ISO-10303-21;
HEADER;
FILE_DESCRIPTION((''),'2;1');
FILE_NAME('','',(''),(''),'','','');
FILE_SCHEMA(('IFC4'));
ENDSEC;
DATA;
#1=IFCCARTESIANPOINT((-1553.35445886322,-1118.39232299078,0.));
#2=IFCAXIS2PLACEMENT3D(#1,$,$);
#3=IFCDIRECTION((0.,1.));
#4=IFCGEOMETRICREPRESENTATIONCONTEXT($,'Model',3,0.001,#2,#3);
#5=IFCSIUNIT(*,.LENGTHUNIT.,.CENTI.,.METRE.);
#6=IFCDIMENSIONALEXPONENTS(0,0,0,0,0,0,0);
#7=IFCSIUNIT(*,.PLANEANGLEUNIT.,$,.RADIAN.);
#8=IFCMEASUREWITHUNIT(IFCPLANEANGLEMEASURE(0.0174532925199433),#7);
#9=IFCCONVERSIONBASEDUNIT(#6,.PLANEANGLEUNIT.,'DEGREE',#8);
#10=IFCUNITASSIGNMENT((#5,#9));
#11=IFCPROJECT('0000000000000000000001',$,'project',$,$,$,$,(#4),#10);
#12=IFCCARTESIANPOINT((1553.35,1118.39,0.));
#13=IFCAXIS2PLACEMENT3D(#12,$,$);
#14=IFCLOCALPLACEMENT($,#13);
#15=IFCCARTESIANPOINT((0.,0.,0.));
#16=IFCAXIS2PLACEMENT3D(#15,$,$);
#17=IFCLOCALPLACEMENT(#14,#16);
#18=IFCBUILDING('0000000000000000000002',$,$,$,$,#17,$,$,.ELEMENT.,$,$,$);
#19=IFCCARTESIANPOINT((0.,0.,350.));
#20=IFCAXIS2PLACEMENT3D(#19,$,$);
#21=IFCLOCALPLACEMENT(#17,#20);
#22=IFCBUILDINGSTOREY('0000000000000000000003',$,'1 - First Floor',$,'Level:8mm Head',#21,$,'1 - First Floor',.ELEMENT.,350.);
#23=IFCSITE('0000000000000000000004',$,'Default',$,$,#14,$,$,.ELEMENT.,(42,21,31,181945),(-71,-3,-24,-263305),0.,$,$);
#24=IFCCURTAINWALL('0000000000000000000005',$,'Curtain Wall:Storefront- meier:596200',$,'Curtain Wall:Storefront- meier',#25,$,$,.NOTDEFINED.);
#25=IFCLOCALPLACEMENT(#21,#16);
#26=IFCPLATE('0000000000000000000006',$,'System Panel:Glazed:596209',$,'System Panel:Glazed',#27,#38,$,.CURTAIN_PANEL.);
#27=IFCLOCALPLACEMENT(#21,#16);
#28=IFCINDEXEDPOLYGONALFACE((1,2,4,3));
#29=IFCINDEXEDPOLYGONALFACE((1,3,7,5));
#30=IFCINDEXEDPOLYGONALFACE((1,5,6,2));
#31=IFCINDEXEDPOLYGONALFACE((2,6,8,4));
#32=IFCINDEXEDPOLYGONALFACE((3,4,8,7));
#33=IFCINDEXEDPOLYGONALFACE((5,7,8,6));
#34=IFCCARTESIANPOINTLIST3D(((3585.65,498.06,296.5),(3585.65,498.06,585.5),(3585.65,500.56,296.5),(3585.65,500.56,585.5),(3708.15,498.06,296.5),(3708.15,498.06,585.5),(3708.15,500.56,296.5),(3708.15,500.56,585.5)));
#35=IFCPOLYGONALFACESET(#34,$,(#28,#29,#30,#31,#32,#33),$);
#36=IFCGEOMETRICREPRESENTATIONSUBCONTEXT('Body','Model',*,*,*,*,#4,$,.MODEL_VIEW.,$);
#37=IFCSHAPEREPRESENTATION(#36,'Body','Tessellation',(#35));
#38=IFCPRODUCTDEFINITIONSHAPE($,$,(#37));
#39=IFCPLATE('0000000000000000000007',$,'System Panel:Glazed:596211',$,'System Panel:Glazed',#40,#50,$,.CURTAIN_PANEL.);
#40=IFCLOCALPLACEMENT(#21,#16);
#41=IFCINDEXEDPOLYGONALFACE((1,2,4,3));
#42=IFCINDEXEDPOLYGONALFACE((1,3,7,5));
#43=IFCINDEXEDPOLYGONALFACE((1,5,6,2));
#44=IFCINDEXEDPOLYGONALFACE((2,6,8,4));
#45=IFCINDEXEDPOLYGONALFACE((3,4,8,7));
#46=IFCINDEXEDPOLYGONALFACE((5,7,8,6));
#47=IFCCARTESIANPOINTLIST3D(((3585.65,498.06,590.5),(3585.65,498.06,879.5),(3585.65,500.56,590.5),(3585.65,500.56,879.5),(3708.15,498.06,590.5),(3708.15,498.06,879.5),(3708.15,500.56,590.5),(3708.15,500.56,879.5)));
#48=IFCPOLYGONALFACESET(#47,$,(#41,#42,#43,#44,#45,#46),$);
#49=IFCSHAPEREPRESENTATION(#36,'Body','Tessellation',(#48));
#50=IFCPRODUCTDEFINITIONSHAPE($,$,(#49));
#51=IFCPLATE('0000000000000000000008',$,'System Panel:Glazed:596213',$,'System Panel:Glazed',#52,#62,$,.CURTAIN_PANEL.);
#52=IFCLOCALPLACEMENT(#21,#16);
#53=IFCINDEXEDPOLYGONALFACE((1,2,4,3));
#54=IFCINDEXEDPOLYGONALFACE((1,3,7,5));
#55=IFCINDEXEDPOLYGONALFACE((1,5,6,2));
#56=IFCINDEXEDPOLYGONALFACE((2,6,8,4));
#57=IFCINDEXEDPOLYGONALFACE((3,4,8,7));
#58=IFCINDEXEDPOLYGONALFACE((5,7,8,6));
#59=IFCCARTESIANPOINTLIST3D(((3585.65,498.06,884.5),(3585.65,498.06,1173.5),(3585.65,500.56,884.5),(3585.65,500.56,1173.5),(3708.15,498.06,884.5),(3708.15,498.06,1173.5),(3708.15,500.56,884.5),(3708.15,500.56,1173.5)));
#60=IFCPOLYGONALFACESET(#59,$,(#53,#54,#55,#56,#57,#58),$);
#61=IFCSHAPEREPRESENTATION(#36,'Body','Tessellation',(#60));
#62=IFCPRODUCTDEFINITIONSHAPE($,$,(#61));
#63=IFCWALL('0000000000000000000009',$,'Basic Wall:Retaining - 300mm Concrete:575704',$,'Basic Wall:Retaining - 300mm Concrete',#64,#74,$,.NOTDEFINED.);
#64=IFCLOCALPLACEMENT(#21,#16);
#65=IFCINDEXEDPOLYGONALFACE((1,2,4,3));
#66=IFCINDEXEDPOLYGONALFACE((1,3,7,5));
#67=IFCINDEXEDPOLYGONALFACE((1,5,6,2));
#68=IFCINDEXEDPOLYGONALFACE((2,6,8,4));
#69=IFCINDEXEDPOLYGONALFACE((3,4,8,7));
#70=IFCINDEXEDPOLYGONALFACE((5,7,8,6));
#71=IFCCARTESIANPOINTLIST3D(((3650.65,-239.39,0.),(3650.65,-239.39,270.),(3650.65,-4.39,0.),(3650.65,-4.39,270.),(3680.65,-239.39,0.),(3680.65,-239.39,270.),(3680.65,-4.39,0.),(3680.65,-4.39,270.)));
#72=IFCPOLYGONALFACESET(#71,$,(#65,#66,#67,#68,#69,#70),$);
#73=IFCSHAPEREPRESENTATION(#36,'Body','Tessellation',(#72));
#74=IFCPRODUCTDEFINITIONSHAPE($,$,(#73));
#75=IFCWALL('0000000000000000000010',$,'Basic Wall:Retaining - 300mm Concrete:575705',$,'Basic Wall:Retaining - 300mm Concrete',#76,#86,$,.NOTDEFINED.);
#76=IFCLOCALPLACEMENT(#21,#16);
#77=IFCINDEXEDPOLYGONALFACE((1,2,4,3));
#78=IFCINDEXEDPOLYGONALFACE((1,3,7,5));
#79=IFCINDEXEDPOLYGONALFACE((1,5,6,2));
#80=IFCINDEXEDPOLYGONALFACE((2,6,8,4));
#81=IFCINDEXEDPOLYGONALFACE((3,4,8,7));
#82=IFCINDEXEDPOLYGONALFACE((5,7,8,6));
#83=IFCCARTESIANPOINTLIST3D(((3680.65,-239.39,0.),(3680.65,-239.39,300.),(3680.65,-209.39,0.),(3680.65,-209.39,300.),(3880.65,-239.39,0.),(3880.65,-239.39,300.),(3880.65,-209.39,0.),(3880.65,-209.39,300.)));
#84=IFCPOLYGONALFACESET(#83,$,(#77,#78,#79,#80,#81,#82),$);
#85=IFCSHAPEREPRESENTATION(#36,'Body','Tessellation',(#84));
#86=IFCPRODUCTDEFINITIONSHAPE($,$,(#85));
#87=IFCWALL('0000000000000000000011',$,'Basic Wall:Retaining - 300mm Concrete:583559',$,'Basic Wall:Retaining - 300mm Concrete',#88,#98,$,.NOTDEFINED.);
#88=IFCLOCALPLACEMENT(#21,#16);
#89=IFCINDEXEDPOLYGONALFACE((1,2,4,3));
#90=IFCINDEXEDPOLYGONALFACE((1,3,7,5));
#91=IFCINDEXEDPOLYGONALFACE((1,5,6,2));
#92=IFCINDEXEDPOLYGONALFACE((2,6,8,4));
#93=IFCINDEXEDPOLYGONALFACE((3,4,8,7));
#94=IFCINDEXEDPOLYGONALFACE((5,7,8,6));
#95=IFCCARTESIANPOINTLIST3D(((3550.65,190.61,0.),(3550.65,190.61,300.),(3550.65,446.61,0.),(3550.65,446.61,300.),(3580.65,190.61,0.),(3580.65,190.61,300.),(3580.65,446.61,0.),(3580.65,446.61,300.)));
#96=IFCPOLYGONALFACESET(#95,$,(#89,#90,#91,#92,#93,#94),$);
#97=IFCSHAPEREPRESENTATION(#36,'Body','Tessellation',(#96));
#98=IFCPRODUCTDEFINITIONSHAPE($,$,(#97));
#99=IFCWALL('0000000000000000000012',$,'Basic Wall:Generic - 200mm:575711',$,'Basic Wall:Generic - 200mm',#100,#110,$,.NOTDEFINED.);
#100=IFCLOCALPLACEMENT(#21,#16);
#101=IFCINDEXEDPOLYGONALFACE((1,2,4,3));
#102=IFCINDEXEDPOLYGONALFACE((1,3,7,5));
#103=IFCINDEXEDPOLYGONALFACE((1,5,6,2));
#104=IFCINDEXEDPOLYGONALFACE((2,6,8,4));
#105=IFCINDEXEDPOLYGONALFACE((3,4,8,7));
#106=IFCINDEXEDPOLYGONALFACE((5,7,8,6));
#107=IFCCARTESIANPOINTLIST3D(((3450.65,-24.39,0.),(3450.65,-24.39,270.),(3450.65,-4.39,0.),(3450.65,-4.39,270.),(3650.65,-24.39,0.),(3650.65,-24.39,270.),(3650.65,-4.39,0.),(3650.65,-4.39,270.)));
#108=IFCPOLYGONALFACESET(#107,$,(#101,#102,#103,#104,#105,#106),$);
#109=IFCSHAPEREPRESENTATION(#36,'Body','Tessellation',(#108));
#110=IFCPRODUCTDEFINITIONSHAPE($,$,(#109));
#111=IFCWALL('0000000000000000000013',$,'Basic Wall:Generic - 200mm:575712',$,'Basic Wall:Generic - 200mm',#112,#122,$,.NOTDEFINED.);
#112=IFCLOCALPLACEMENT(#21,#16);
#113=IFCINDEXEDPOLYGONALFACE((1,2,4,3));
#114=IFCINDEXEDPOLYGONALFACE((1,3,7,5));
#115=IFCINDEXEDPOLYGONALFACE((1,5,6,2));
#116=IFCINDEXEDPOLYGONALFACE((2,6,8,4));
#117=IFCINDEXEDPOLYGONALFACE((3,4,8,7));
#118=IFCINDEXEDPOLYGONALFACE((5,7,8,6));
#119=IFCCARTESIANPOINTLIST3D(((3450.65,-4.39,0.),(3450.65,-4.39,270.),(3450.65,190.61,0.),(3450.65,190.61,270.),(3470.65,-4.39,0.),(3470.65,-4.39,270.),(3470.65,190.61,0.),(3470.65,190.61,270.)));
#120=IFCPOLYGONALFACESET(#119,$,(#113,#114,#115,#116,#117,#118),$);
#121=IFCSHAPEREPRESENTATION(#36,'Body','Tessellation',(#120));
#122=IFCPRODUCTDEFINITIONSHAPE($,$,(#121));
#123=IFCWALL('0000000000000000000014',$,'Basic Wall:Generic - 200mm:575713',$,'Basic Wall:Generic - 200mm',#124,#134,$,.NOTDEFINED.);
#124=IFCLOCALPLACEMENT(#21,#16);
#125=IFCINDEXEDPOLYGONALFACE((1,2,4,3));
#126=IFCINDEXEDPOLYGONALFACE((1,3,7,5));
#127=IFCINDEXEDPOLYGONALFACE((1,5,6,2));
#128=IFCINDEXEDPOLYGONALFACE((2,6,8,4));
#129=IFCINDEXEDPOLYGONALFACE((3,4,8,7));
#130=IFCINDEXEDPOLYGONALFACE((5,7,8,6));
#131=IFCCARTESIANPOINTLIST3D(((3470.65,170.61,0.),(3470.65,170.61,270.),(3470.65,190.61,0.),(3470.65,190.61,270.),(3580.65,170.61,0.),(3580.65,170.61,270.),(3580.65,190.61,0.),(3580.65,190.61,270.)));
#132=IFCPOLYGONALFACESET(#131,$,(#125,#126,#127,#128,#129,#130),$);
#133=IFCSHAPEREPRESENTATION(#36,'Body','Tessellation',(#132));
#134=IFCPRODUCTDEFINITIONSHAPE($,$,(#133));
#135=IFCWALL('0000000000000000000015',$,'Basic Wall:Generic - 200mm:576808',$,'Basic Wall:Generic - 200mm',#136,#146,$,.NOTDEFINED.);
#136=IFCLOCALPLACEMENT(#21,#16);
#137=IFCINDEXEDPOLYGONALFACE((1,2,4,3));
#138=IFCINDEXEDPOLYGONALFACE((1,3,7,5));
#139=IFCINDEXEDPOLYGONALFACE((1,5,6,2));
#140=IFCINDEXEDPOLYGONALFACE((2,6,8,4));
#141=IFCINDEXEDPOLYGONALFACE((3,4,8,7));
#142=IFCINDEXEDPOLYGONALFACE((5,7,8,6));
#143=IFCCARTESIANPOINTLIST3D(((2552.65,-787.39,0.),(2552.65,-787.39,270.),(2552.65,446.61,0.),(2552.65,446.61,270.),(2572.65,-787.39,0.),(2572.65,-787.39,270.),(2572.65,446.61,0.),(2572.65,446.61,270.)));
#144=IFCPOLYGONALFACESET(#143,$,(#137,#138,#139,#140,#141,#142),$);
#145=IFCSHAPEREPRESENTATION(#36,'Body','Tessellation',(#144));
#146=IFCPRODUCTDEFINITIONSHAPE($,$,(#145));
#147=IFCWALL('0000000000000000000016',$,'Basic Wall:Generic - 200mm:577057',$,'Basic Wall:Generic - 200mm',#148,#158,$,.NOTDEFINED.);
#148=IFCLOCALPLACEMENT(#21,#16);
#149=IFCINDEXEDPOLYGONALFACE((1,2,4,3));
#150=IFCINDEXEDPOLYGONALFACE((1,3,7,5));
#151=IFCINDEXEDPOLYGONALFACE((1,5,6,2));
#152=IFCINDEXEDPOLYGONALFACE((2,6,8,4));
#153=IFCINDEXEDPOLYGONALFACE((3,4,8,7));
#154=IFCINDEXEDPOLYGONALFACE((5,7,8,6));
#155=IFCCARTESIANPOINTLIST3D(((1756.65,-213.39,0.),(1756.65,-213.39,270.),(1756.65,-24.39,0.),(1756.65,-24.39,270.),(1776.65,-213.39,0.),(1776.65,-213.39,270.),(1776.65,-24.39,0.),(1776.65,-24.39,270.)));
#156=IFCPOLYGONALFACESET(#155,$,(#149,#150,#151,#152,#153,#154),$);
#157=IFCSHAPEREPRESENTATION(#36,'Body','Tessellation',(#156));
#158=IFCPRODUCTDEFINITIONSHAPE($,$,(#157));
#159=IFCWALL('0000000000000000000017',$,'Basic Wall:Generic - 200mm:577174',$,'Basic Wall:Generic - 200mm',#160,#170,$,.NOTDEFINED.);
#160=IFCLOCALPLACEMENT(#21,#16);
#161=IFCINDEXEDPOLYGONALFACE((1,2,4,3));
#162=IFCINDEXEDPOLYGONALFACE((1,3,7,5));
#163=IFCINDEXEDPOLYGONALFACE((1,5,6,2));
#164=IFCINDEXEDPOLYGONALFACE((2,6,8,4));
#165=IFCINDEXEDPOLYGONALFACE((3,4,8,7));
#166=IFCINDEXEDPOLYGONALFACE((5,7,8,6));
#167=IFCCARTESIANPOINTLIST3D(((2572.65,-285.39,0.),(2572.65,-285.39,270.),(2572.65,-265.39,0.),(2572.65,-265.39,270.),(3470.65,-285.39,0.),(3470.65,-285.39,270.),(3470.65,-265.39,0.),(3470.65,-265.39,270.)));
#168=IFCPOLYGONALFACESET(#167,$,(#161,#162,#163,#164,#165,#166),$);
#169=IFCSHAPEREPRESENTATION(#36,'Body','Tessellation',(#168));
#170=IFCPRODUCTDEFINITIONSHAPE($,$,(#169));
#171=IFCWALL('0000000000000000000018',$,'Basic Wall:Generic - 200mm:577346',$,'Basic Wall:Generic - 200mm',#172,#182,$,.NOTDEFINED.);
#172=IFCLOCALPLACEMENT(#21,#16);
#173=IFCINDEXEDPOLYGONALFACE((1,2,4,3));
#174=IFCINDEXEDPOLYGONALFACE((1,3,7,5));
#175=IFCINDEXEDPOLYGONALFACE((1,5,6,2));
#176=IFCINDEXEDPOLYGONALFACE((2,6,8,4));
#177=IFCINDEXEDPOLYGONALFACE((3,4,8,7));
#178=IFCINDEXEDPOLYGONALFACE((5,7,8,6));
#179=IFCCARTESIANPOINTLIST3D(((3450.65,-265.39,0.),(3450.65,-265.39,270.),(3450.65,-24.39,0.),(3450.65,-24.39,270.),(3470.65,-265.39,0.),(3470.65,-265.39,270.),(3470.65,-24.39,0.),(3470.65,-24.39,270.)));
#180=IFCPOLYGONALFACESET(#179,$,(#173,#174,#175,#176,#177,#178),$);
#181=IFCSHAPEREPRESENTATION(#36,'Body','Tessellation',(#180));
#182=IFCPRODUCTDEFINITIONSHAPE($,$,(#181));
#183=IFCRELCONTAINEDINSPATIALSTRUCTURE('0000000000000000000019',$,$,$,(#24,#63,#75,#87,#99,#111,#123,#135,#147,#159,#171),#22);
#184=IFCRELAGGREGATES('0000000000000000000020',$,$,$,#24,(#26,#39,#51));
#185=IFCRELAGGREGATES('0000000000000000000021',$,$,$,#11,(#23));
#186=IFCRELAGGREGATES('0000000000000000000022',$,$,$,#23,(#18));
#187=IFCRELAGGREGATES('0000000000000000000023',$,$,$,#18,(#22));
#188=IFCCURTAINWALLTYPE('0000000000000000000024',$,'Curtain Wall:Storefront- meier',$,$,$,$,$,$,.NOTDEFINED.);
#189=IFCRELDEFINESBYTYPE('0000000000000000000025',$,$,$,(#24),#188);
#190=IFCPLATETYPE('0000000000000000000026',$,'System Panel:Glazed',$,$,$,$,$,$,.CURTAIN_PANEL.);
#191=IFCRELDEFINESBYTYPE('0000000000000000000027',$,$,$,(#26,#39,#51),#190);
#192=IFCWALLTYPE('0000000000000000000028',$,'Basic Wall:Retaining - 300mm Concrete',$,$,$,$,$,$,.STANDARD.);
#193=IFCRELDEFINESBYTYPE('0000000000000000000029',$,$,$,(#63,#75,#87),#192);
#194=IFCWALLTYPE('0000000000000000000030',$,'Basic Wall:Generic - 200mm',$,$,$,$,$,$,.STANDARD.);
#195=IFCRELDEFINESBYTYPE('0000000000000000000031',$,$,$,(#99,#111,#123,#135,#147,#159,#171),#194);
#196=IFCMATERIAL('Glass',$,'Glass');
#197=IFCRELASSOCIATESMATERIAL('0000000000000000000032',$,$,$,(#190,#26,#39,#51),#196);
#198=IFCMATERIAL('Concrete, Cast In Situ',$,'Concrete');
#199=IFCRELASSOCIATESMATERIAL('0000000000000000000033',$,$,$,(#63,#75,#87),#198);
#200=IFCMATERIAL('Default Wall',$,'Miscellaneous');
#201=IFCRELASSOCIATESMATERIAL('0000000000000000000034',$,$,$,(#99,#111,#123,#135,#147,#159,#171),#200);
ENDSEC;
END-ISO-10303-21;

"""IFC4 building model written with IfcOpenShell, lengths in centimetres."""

from ifc_helpers import new_model, entity, si_unit, converted_unit, direction, frame, origin, place, context, subcontext, project, spatial, indexed_curve, outline, extrude, source, transform, mapped, material, type_object, type_shapes, element, aggregate, save


model = new_model("IFC4")

# Units and contexts
model_context = context("Model", 3, precision=0.001, world=frame((-1553.35445886322, -1118.39232299078, 0.0)), true_north=direction((0.0, 1.0)))
body_context = subcontext(model_context, "Body", "Model", "MODEL_VIEW")
ifc_project = project(units=[si_unit("LENGTHUNIT", "METRE", prefix="CENTI"), converted_unit("PLANEANGLEUNIT", "DEGREE", entity("IfcPlaneAngleMeasure", 0.0174532925199433), si_unit("PLANEANGLEUNIT", "RADIAN"), dimensions=[0, 0, 0, 0, 0, 0, 0])], contexts=[model_context])

# Site, building, storey
site_placement = place(None, frame((1553.35, 1118.39, 0.0)))
site = spatial("IfcSite", under=ifc_project, at=site_placement, Name="Default", CompositionType="ELEMENT", RefLatitude=(42, 21, 31, 181945), RefLongitude=(-71, -3, -24, -263305), RefElevation=0.0)
building_placement = place(site_placement, origin())
building = spatial("IfcBuilding", under=site, at=building_placement, CompositionType="ELEMENT")
storey_placement = place(building_placement, frame((0.0, 0.0, 350.0)))
storey = spatial("IfcBuildingStorey", under=building, at=storey_placement, Name="1 - First Floor", ObjectType="Level:8mm Head", LongName="1 - First Floor", CompositionType="ELEMENT", Elevation=350.0)

# Curtain wall, plates
curtain_wall_type = type_object("IfcCurtainWallType", Name="Curtain Wall:Storefront- meier", PredefinedType="NOTDEFINED")
curtain_wall_placement = place(storey_placement, frame((0.0, 0.0, -350.0)))
curtain_wall = element("IfcCurtainWall", 1, at=curtain_wall_placement, inside=storey, type_object=curtain_wall_type, Name="Curtain Wall:Storefront- meier:596200", ObjectType="Curtain Wall:Storefront- meier", PredefinedType="NOTDEFINED")
ifc_material_1 = material(Name="Glass", Category="Glass")
plate_type_1 = type_object("IfcPlateType", Name="System Panel:Glazed", PredefinedType="CURTAIN_PANEL", material=ifc_material_1)
shared_shape_1 = source(origin(), body_context, "Body", "SweptSolid", [
    extrude(outline(indexed_curve([(-1.25, -61.25), (1.25, -61.25), (1.25, 61.25), (-1.25, 61.25), (-1.25, -61.25)], self_intersect=False)), frame((0.0, 3.7, 0.0), z_axis=(0.0, 0.0, 1.0), x_axis=(0.0, 1.0, 0.0)), (0.0, 0.0, 1.0), 289.0),
])
type_shapes(plate_type_1, [shared_shape_1])
plate_1_placement = place(curtain_wall_placement, frame((3646.9, 495.61, 646.5)))
plate_1 = element("IfcPlate", 2, at=plate_1_placement, type_object=plate_type_1, material=ifc_material_1, Name="System Panel:Glazed:596209", ObjectType="System Panel:Glazed", PredefinedType="CURTAIN_PANEL", context=body_context, shape_type="MappedRepresentation", body=[
    mapped(shared_shape_1, transform((0.0, 0.0, 0.0), scale=1.0)),
])
plate_2_placement = place(curtain_wall_placement, frame((3646.9, 495.61, 940.5)))
plate_2 = element("IfcPlate", 3, at=plate_2_placement, type_object=plate_type_1, material=ifc_material_1, Name="System Panel:Glazed:596211", ObjectType="System Panel:Glazed", PredefinedType="CURTAIN_PANEL", context=body_context, shape_type="MappedRepresentation", body=[
    mapped(shared_shape_1, transform((0.0, 0.0, 0.0), scale=1.0)),
])
plate_3_placement = place(curtain_wall_placement, frame((3646.9, 495.61, 1234.5)))
plate_3 = element("IfcPlate", 4, at=plate_3_placement, type_object=plate_type_1, material=ifc_material_1, Name="System Panel:Glazed:596213", ObjectType="System Panel:Glazed", PredefinedType="CURTAIN_PANEL", context=body_context, shape_type="MappedRepresentation", body=[
    mapped(shared_shape_1, transform((0.0, 0.0, 0.0), scale=1.0)),
])
aggregate(curtain_wall, [plate_1, plate_2, plate_3])

# Walls
ifc_material_2 = material(Name="Concrete, Cast In Situ", Category="Concrete")
wall_type_1 = type_object("IfcWallType", Name="Basic Wall:Retaining - 300mm Concrete", PredefinedType="STANDARD")
wall_1_placement = place(storey_placement, frame((3665.65, -4.39, 0.0), z_axis=(0.0, 0.0, 1.0), x_axis=(0.0, -1.0, 0.0)))
element("IfcWall", 5, at=wall_1_placement, inside=storey, type_object=wall_type_1, material=ifc_material_2, Name="Basic Wall:Retaining - 300mm Concrete:575704", ObjectType="Basic Wall:Retaining - 300mm Concrete", PredefinedType="NOTDEFINED", context=body_context, shape_type="SweptSolid", body=[
    extrude(outline(indexed_curve([(235.0, 15.0), (0.0, 15.0), (0.0, -15.0), (235.0, -15.0), (235.0, 15.0)], self_intersect=False)), origin(), (0.0, 0.0, 1.0), 270.0),
])
wall_2_placement = place(storey_placement, frame((3680.65, -224.39, 0.0)))
element("IfcWall", 6, at=wall_2_placement, inside=storey, type_object=wall_type_1, material=ifc_material_2, Name="Basic Wall:Retaining - 300mm Concrete:575705", ObjectType="Basic Wall:Retaining - 300mm Concrete", PredefinedType="NOTDEFINED", context=body_context, shape_type="SweptSolid", body=[
    extrude(outline(indexed_curve([(200.0, 15.0), (0.0, 15.0), (0.0, -15.0), (200.0, -15.0), (200.0, 15.0)], self_intersect=False)), origin(), (0.0, 0.0, 1.0), 300.0),
])
wall_3_placement = place(storey_placement, frame((3565.65, 446.61, 0.0), z_axis=(0.0, 0.0, 1.0), x_axis=(0.0, -1.0, 0.0)))
element("IfcWall", 7, at=wall_3_placement, inside=storey, type_object=wall_type_1, material=ifc_material_2, Name="Basic Wall:Retaining - 300mm Concrete:583559", ObjectType="Basic Wall:Retaining - 300mm Concrete", PredefinedType="NOTDEFINED", context=body_context, shape_type="SweptSolid", body=[
    extrude(outline(indexed_curve([(256.0, 15.0), (0.0, 15.0), (0.0, -15.0), (256.0, -15.0), (256.0, 15.0)], self_intersect=False)), origin(), (0.0, 0.0, 1.0), 300.0),
])
ifc_material_3 = material(Name="Default Wall", Category="Miscellaneous")
wall_type_2 = type_object("IfcWallType", Name="Basic Wall:Generic - 200mm", PredefinedType="STANDARD")
wall_4_placement = place(storey_placement, frame((3650.65, -14.39, 0.0), z_axis=(0.0, 0.0, 1.0), x_axis=(-1.0, 0.0, 0.0)))
element("IfcWall", 8, at=wall_4_placement, inside=storey, type_object=wall_type_2, material=ifc_material_3, Name="Basic Wall:Generic - 200mm:575711", ObjectType="Basic Wall:Generic - 200mm", PredefinedType="NOTDEFINED", context=body_context, shape_type="SweptSolid", body=[
    extrude(outline(indexed_curve([(200.0, 10.0), (0.0, 10.0), (0.0, -10.0), (200.0, -10.0), (200.0, 10.0)], self_intersect=False)), origin(), (0.0, 0.0, 1.0), 270.0),
])
wall_5_placement = place(storey_placement, frame((3460.65, -4.39, 0.0), z_axis=(0.0, 0.0, 1.0), x_axis=(0.0, 1.0, 0.0)))
element("IfcWall", 9, at=wall_5_placement, inside=storey, type_object=wall_type_2, material=ifc_material_3, Name="Basic Wall:Generic - 200mm:575712", ObjectType="Basic Wall:Generic - 200mm", PredefinedType="NOTDEFINED", context=body_context, shape_type="SweptSolid", body=[
    extrude(outline(indexed_curve([(195.0, 10.0), (0.0, 10.0), (0.0, -10.0), (195.0, -10.0), (195.0, 10.0)], self_intersect=False)), origin(), (0.0, 0.0, 1.0), 270.0),
])
wall_6_placement = place(storey_placement, frame((3470.65, 180.61, 0.0)))
element("IfcWall", 10, at=wall_6_placement, inside=storey, type_object=wall_type_2, material=ifc_material_3, Name="Basic Wall:Generic - 200mm:575713", ObjectType="Basic Wall:Generic - 200mm", PredefinedType="NOTDEFINED", context=body_context, shape_type="SweptSolid", body=[
    extrude(outline(indexed_curve([(110.0, 10.0), (0.0, 10.0), (0.0, -10.0), (110.0, -10.0), (110.0, 10.0)], self_intersect=False)), origin(), (0.0, 0.0, 1.0), 270.0),
])
wall_7_placement = place(storey_placement, frame((2562.65, 446.61, 0.0), z_axis=(0.0, 0.0, 1.0), x_axis=(0.0, -1.0, 0.0)))
element("IfcWall", 11, at=wall_7_placement, inside=storey, type_object=wall_type_2, material=ifc_material_3, Name="Basic Wall:Generic - 200mm:576808", ObjectType="Basic Wall:Generic - 200mm", PredefinedType="NOTDEFINED", context=body_context, shape_type="SweptSolid", body=[
    extrude(outline(indexed_curve([(1234.0, 10.0), (0.0, 10.0), (0.0, -10.0), (1234.0, -10.0), (1234.0, 10.0)], self_intersect=False)), origin(), (0.0, 0.0, 1.0), 270.0),
])
wall_8_placement = place(storey_placement, frame((1766.65, -24.39, 0.0), z_axis=(0.0, 0.0, 1.0), x_axis=(0.0, -1.0, 0.0)))
element("IfcWall", 12, at=wall_8_placement, inside=storey, type_object=wall_type_2, material=ifc_material_3, Name="Basic Wall:Generic - 200mm:577057", ObjectType="Basic Wall:Generic - 200mm", PredefinedType="NOTDEFINED", context=body_context, shape_type="SweptSolid", body=[
    extrude(outline(indexed_curve([(189.0, 10.0), (0.0, 10.0), (0.0, -10.0), (189.0, -10.0), (189.0, 10.0)], self_intersect=False)), origin(), (0.0, 0.0, 1.0), 270.0),
])
wall_9_placement = place(storey_placement, frame((2572.65, -275.39, 0.0)))
element("IfcWall", 13, at=wall_9_placement, inside=storey, type_object=wall_type_2, material=ifc_material_3, Name="Basic Wall:Generic - 200mm:577174", ObjectType="Basic Wall:Generic - 200mm", PredefinedType="NOTDEFINED", context=body_context, shape_type="SweptSolid", body=[
    extrude(outline(indexed_curve([(898.0, 10.0), (0.0, 10.0), (0.0, -10.0), (898.0, -10.0), (898.0, 10.0)], self_intersect=False)), origin(), (0.0, 0.0, 1.0), 270.0),
])
wall_10_placement = place(storey_placement, frame((3460.65, -24.39, 0.0), z_axis=(0.0, 0.0, 1.0), x_axis=(0.0, -1.0, 0.0)))
element("IfcWall", 14, at=wall_10_placement, inside=storey, type_object=wall_type_2, material=ifc_material_3, Name="Basic Wall:Generic - 200mm:577346", ObjectType="Basic Wall:Generic - 200mm", PredefinedType="NOTDEFINED", context=body_context, shape_type="SweptSolid", body=[
    extrude(outline(indexed_curve([(241.0, 10.0), (0.0, 10.0), (0.0, -10.0), (241.0, -10.0), (241.0, 10.0)], self_intersect=False)), origin(), (0.0, 0.0, 1.0), 270.0),
])

save(model, "model.ifc")
